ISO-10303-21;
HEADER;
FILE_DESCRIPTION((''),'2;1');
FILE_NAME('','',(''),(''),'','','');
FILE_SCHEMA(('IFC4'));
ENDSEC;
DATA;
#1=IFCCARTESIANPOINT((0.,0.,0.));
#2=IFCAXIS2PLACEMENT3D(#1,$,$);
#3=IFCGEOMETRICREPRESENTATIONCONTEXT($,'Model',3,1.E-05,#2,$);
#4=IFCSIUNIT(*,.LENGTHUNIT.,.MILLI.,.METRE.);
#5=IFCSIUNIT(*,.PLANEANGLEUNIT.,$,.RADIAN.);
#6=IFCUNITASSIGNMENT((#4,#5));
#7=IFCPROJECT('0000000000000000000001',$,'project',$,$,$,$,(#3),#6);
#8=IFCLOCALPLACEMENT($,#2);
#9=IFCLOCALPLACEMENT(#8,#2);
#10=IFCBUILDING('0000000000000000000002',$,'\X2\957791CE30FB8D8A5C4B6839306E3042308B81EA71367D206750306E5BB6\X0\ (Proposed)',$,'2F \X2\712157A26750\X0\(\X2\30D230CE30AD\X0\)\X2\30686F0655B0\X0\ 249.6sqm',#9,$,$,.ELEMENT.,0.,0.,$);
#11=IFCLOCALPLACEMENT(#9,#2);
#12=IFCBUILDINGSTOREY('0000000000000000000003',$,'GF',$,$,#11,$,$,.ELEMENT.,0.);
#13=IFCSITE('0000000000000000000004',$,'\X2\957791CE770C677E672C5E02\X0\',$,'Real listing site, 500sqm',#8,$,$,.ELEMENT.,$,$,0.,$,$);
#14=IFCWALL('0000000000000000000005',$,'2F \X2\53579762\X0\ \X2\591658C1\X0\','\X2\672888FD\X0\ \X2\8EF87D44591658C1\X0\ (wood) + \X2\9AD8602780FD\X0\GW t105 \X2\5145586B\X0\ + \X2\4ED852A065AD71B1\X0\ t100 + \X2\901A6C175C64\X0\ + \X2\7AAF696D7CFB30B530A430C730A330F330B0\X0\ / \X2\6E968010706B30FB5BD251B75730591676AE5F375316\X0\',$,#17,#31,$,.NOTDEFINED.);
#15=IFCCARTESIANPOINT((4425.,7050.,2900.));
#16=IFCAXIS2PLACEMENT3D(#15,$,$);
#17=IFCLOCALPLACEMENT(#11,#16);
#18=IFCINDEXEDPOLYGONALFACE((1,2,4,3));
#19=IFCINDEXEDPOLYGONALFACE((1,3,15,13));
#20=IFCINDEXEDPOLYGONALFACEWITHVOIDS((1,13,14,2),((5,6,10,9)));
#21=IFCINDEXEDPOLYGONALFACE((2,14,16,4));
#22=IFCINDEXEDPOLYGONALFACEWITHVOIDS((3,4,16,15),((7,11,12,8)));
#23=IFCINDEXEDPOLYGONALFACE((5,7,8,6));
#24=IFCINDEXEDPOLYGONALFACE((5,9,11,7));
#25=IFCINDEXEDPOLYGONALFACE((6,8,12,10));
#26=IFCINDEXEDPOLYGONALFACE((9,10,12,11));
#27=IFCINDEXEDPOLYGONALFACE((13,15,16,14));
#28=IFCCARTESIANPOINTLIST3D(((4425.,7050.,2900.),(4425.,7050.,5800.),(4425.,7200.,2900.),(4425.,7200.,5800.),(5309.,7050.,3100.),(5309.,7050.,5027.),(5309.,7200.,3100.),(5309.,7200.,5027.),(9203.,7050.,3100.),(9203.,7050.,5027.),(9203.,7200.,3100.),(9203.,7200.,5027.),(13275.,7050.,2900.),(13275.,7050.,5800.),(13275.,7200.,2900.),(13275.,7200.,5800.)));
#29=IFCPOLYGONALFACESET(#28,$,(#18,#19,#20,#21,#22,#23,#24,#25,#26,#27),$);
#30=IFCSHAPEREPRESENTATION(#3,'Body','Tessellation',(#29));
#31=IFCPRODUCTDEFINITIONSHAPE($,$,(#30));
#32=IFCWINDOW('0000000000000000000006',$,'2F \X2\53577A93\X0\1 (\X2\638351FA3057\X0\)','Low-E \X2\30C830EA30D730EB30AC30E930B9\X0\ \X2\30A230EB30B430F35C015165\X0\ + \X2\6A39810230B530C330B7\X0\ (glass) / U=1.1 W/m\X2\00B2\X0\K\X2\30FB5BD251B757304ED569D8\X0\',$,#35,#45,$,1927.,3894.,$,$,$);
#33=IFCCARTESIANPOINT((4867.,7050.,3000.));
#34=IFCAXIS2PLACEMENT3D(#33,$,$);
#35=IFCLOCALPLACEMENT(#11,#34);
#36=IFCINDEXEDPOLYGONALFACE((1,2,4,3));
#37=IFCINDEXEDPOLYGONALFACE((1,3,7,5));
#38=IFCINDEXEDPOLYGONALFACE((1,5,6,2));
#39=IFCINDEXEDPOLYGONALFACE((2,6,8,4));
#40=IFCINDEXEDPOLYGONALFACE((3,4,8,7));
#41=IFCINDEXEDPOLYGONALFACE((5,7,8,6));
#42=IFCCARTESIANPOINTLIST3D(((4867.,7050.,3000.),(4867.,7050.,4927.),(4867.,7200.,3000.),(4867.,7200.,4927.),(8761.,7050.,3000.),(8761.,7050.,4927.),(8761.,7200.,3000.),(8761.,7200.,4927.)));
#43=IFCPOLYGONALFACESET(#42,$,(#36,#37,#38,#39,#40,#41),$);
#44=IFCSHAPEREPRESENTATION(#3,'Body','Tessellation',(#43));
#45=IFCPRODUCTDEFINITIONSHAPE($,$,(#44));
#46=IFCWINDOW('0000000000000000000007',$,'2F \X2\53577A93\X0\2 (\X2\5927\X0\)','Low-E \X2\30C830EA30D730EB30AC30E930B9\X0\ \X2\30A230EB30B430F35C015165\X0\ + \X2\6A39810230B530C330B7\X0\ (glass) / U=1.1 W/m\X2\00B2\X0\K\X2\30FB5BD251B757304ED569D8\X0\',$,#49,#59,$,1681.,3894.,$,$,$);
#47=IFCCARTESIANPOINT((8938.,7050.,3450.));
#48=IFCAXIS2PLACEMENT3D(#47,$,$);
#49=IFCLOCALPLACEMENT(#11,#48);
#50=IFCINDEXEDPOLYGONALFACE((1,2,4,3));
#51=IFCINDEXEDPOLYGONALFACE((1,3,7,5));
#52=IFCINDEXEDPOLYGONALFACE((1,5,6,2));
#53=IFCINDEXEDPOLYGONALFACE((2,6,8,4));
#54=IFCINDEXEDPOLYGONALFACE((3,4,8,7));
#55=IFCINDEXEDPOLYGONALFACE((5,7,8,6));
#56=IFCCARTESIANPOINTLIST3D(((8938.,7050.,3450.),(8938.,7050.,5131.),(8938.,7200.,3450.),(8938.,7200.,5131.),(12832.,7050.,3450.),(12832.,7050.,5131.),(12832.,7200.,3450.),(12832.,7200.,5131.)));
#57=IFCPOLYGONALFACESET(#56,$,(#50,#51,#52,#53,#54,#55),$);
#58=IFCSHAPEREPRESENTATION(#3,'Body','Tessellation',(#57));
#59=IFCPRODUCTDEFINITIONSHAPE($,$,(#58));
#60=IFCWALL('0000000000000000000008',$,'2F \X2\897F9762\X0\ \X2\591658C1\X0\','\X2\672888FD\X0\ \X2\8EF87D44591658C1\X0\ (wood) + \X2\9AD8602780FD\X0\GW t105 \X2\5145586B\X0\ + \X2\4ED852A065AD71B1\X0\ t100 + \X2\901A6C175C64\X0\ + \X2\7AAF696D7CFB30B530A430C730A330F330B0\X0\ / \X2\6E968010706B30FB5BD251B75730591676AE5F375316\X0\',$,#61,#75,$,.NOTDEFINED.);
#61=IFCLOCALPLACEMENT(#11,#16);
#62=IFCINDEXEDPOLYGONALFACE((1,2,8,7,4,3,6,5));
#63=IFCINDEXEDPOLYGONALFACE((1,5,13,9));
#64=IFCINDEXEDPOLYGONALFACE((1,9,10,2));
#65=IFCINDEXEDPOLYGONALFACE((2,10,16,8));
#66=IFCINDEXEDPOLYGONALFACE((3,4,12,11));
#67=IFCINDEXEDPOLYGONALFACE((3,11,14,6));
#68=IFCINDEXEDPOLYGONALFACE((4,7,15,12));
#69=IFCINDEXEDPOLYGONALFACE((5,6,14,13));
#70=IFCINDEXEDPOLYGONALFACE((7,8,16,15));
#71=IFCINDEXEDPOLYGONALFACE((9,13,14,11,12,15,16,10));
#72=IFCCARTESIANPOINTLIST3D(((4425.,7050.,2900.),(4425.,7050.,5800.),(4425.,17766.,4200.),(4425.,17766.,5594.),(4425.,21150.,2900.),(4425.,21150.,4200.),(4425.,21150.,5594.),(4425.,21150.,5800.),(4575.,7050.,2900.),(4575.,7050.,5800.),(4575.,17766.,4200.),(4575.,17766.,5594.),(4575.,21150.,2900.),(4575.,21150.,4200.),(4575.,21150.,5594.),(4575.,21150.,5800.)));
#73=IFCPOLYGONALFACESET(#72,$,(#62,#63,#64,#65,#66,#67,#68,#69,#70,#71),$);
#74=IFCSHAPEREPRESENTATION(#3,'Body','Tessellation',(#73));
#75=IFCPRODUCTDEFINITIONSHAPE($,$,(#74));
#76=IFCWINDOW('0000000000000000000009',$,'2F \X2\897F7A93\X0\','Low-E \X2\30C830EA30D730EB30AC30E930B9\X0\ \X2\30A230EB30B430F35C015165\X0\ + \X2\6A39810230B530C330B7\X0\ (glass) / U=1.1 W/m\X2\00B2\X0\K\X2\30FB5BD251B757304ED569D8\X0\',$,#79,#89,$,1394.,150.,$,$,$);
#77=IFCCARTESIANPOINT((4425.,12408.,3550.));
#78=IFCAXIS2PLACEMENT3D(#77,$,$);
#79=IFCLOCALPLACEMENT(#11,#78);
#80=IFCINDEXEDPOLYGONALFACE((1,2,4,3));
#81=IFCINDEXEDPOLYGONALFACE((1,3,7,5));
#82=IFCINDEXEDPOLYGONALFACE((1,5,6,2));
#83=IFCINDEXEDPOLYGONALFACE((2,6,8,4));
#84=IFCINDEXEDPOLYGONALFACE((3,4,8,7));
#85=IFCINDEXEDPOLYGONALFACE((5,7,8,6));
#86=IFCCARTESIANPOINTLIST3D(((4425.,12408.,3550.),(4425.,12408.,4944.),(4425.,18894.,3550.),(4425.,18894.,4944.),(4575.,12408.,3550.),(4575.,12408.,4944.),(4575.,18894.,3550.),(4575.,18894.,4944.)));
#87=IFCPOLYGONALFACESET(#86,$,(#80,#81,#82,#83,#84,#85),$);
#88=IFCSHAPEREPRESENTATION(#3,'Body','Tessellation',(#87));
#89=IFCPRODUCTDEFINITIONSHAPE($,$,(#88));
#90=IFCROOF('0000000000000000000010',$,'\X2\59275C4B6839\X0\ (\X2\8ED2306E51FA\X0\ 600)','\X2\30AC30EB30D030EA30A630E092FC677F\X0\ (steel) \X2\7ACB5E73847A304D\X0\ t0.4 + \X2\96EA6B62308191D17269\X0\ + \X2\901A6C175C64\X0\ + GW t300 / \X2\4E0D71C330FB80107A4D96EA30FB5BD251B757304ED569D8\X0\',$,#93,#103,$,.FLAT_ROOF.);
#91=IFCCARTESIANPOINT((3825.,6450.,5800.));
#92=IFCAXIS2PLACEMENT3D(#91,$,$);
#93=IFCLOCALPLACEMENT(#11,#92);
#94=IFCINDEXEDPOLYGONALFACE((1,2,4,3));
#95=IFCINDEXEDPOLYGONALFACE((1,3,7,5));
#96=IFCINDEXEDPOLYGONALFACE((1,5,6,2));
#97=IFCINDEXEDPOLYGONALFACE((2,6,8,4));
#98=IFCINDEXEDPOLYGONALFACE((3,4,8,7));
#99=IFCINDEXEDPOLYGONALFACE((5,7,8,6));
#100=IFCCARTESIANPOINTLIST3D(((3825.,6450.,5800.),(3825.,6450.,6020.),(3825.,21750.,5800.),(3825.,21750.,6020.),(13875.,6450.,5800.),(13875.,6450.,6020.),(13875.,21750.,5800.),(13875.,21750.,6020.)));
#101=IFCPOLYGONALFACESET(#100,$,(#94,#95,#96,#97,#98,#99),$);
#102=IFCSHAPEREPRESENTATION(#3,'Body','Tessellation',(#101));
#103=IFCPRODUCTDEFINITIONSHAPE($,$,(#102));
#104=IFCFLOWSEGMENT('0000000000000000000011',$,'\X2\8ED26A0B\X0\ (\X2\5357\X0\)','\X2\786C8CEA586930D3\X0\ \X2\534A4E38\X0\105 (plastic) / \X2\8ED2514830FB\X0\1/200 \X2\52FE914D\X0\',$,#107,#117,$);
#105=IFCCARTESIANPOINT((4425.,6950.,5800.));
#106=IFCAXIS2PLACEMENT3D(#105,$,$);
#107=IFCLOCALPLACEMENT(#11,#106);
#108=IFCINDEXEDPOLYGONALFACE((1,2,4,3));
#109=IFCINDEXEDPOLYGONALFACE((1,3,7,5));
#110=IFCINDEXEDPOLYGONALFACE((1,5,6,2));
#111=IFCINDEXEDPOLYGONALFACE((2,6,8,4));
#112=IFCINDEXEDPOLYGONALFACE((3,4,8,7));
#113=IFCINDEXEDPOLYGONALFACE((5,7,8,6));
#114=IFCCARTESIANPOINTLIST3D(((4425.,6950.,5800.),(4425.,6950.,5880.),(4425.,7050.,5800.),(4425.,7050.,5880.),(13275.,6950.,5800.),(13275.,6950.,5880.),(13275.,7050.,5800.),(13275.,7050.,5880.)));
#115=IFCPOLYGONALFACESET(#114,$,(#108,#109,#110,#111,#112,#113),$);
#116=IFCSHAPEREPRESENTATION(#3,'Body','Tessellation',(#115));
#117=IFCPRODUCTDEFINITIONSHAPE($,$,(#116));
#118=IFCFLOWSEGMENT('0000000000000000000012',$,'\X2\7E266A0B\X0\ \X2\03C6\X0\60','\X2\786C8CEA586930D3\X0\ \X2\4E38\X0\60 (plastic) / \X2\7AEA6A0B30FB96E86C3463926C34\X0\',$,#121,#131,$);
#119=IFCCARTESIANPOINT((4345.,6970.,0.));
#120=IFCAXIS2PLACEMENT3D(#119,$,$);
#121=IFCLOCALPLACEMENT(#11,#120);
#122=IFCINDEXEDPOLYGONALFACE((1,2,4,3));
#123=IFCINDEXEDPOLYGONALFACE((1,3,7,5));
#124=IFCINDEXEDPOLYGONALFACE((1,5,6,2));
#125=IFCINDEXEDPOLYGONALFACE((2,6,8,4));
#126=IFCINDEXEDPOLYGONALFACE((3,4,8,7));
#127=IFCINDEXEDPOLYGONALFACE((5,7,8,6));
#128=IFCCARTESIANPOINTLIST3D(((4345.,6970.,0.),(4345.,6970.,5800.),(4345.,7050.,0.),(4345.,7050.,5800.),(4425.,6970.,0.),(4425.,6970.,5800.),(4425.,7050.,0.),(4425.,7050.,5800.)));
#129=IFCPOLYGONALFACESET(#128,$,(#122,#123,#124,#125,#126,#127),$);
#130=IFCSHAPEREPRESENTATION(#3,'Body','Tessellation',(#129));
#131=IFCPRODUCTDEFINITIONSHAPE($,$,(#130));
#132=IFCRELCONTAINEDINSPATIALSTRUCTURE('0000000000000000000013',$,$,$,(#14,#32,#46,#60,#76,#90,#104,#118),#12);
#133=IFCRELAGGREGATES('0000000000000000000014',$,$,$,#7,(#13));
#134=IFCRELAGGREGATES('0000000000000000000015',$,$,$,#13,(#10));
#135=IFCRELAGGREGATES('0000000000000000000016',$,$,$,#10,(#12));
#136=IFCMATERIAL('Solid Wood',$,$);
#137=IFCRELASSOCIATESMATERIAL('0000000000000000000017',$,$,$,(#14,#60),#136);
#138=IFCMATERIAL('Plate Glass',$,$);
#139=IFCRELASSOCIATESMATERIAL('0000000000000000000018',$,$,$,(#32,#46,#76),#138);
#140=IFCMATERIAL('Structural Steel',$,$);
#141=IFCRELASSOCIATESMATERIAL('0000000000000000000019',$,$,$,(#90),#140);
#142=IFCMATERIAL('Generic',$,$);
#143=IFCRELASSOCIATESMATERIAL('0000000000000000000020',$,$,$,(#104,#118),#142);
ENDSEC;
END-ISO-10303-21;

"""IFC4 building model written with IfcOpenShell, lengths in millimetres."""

from ifc_helpers import new_model, si_unit, frame, frame_2d, origin, place, context, project, spatial, rectangle, extrude, material, element, fill, save


model = new_model("IFC4")

# Units and contexts
model_context = context("Model", 3, precision=1e-05, world=origin())
ifc_project = project(units=[si_unit("LENGTHUNIT", "METRE", prefix="MILLI"), si_unit("PLANEANGLEUNIT", "RADIAN")], contexts=[model_context])

# Site, building, storey
site_placement = place(None, origin())
site = spatial("IfcSite", under=ifc_project, at=site_placement, Name="長野県松本市", ObjectType="Real listing site, 500sqm", CompositionType="ELEMENT", RefElevation=0.0)
building_placement = place(site_placement, origin())
building = spatial("IfcBuilding", under=site, at=building_placement, Name="長野・越屋根のある自然素材の家 (Proposed)", ObjectType="2F 無垢材(ヒノキ)と漆喰 249.6sqm", CompositionType="ELEMENT", ElevationOfRefHeight=0.0, ElevationOfTerrain=0.0)
storey_placement = place(building_placement, origin())
storey = spatial("IfcBuildingStorey", under=building, at=storey_placement, Name="GF", CompositionType="ELEMENT", Elevation=0.0)

# Shared definitions
ifc_material_1 = material(Name="Solid Wood")

# Shared definitions
ifc_material_2 = material(Name="Plate Glass")

# Wall, openings, windows
wall_1_placement = place(storey_placement, frame((4425.0, 7050.0, 2900.0)))
wall_1 = element("IfcWall", 1, at=wall_1_placement, inside=storey, material=ifc_material_1, Name="2F 南面 外壁", Description="木製 軸組外壁 (wood) + 高性能GW t105 充填 + 付加断熱 t100 + 通気層 + 窯業系サイディング / 準耐火・寒冷地外皮強化", PredefinedType="NOTDEFINED", context=model_context, shape_type="SweptSolid", body=[
    extrude(rectangle(XDim=8850.0, YDim=150.0, at=frame_2d((4425.0, 75.0))), frame((4425.0, 7050.0, 2900.0)), (0.0, 0.0, 1.0), 2900.0),
])
opening_1_placement = place(storey_placement, frame((4867.0, 7050.0, 3000.0)))
opening_1 = element("IfcOpeningElement", 2, at=opening_1_placement, cuts=wall_1, PredefinedType="NOTDEFINED", context=model_context, shape_type="SweptSolid", body=[
    extrude(rectangle(XDim=3894.0, YDim=150.0, at=frame_2d((1947.0, 75.0))), frame((4867.0, 7050.0, 3000.0)), (0.0, 0.0, 1.0), 1927.0),
])
opening_2_placement = place(storey_placement, frame((8938.0, 7050.0, 3450.0)))
opening_2 = element("IfcOpeningElement", 3, at=opening_2_placement, cuts=wall_1, PredefinedType="NOTDEFINED", context=model_context, shape_type="SweptSolid", body=[
    extrude(rectangle(XDim=3894.0, YDim=150.0, at=frame_2d((1947.0, 75.0))), frame((8938.0, 7050.0, 3450.0)), (0.0, 0.0, 1.0), 1681.0),
])
window_1_placement = place(storey_placement, frame((4867.0, 7050.0, 3000.0)))
window_1 = element("IfcWindow", 4, at=window_1_placement, inside=storey, material=ifc_material_2, Name="2F 南窓1 (掃出し)", Description="Low-E トリプルガラス アルゴン封入 + 樹脂サッシ (glass) / U=1.1 W/m²K・寒冷地仕様", OverallHeight=1927.0, OverallWidth=3894.0, context=model_context, shape_type="SweptSolid", body=[
    extrude(rectangle(XDim=3894.0, YDim=150.0, at=frame_2d((1947.0, 75.0))), frame((4867.0, 7050.0, 3000.0)), (0.0, 0.0, 1.0), 1927.0),
])
fill(opening_1, window_1)
window_2_placement = place(storey_placement, frame((8938.0, 7050.0, 3450.0)))
window_2 = element("IfcWindow", 5, at=window_2_placement, inside=storey, material=ifc_material_2, Name="2F 南窓2 (大)", Description="Low-E トリプルガラス アルゴン封入 + 樹脂サッシ (glass) / U=1.1 W/m²K・寒冷地仕様", OverallHeight=1681.0, OverallWidth=3894.0, context=model_context, shape_type="SweptSolid", body=[
    extrude(rectangle(XDim=3894.0, YDim=150.0, at=frame_2d((1947.0, 75.0))), frame((8938.0, 7050.0, 3450.0)), (0.0, 0.0, 1.0), 1681.0),
])
fill(opening_2, window_2)

# Wall, opening, window
wall_2_placement = place(storey_placement, frame((4425.0, 7050.0, 2900.0)))
wall_2 = element("IfcWall", 6, at=wall_2_placement, inside=storey, material=ifc_material_1, Name="2F 西面 外壁", Description="木製 軸組外壁 (wood) + 高性能GW t105 充填 + 付加断熱 t100 + 通気層 + 窯業系サイディング / 準耐火・寒冷地外皮強化", PredefinedType="NOTDEFINED", context=model_context, shape_type="SweptSolid", body=[
    extrude(rectangle(XDim=150.0, YDim=14100.0, at=frame_2d((75.0, 7050.0))), frame((4425.0, 7050.0, 2900.0)), (0.0, 0.0, 1.0), 2900.0),
])
opening_3_placement = place(storey_placement, frame((4425.0, 12408.0, 3550.0)))
opening_3 = element("IfcOpeningElement", 7, at=opening_3_placement, cuts=wall_2, PredefinedType="NOTDEFINED", context=model_context, shape_type="SweptSolid", body=[
    extrude(rectangle(XDim=150.0, YDim=6486.0, at=frame_2d((75.0, 3243.0))), frame((4425.0, 12408.0, 3550.0)), (0.0, 0.0, 1.0), 1394.0),
])
window_3_placement = place(storey_placement, frame((4425.0, 12408.0, 3550.0)))
window_3 = element("IfcWindow", 8, at=window_3_placement, inside=storey, material=ifc_material_2, Name="2F 西窓", Description="Low-E トリプルガラス アルゴン封入 + 樹脂サッシ (glass) / U=1.1 W/m²K・寒冷地仕様", OverallHeight=1394.0, OverallWidth=150.0, context=model_context, shape_type="SweptSolid", body=[
    extrude(rectangle(XDim=150.0, YDim=6486.0, at=frame_2d((75.0, 3243.0))), frame((4425.0, 12408.0, 3550.0)), (0.0, 0.0, 1.0), 1394.0),
])
fill(opening_3, window_3)

# Roof
ifc_material_3 = material(Name="Structural Steel")
roof_placement = place(storey_placement, frame((3825.0, 6450.0, 5800.0)))
element("IfcRoof", 9, at=roof_placement, inside=storey, material=ifc_material_3, Name="大屋根 (軒の出 600)", Description="ガルバリウム鋼板 (steel) 立平葺き t0.4 + 雪止め金物 + 通気層 + GW t300 / 不燃・耐積雪・寒冷地仕様", PredefinedType="FLAT_ROOF", context=model_context, shape_type="SweptSolid", body=[
    extrude(rectangle(XDim=10050.0, YDim=15300.0, at=frame_2d((5025.0, 7650.0))), frame((3825.0, 6450.0, 5800.0)), (0.0, 0.0, 1.0), 220.0),
])

# Flow segments
ifc_material_4 = material(Name="Generic")
flow_segment_1_placement = place(storey_placement, frame((4425.0, 6950.0, 5800.0)))
element("IfcFlowSegment", 10, at=flow_segment_1_placement, inside=storey, material=ifc_material_4, Name="軒樋 (南)", Description="硬質塩ビ 半丸105 (plastic) / 軒先・1/200 勾配", context=model_context, shape_type="SweptSolid", body=[
    extrude(rectangle(XDim=8850.0, YDim=100.0, at=frame_2d((4425.0, 50.0))), frame((4425.0, 6950.0, 5800.0)), (0.0, 0.0, 1.0), 80.0),
])
flow_segment_2_placement = place(storey_placement, frame((4345.0, 6970.0, 0.0)))
element("IfcFlowSegment", 11, at=flow_segment_2_placement, inside=storey, material=ifc_material_4, Name="縦樋 φ60", Description="硬質塩ビ 丸60 (plastic) / 竪樋・雨水排水", context=model_context, shape_type="SweptSolid", body=[
    extrude(rectangle(XDim=80.0, YDim=80.0, at=frame_2d((40.0, 40.0))), frame((4345.0, 6970.0, 0.0)), (0.0, 0.0, 1.0), 5800.0),
])

save(model, "model.ifc")
